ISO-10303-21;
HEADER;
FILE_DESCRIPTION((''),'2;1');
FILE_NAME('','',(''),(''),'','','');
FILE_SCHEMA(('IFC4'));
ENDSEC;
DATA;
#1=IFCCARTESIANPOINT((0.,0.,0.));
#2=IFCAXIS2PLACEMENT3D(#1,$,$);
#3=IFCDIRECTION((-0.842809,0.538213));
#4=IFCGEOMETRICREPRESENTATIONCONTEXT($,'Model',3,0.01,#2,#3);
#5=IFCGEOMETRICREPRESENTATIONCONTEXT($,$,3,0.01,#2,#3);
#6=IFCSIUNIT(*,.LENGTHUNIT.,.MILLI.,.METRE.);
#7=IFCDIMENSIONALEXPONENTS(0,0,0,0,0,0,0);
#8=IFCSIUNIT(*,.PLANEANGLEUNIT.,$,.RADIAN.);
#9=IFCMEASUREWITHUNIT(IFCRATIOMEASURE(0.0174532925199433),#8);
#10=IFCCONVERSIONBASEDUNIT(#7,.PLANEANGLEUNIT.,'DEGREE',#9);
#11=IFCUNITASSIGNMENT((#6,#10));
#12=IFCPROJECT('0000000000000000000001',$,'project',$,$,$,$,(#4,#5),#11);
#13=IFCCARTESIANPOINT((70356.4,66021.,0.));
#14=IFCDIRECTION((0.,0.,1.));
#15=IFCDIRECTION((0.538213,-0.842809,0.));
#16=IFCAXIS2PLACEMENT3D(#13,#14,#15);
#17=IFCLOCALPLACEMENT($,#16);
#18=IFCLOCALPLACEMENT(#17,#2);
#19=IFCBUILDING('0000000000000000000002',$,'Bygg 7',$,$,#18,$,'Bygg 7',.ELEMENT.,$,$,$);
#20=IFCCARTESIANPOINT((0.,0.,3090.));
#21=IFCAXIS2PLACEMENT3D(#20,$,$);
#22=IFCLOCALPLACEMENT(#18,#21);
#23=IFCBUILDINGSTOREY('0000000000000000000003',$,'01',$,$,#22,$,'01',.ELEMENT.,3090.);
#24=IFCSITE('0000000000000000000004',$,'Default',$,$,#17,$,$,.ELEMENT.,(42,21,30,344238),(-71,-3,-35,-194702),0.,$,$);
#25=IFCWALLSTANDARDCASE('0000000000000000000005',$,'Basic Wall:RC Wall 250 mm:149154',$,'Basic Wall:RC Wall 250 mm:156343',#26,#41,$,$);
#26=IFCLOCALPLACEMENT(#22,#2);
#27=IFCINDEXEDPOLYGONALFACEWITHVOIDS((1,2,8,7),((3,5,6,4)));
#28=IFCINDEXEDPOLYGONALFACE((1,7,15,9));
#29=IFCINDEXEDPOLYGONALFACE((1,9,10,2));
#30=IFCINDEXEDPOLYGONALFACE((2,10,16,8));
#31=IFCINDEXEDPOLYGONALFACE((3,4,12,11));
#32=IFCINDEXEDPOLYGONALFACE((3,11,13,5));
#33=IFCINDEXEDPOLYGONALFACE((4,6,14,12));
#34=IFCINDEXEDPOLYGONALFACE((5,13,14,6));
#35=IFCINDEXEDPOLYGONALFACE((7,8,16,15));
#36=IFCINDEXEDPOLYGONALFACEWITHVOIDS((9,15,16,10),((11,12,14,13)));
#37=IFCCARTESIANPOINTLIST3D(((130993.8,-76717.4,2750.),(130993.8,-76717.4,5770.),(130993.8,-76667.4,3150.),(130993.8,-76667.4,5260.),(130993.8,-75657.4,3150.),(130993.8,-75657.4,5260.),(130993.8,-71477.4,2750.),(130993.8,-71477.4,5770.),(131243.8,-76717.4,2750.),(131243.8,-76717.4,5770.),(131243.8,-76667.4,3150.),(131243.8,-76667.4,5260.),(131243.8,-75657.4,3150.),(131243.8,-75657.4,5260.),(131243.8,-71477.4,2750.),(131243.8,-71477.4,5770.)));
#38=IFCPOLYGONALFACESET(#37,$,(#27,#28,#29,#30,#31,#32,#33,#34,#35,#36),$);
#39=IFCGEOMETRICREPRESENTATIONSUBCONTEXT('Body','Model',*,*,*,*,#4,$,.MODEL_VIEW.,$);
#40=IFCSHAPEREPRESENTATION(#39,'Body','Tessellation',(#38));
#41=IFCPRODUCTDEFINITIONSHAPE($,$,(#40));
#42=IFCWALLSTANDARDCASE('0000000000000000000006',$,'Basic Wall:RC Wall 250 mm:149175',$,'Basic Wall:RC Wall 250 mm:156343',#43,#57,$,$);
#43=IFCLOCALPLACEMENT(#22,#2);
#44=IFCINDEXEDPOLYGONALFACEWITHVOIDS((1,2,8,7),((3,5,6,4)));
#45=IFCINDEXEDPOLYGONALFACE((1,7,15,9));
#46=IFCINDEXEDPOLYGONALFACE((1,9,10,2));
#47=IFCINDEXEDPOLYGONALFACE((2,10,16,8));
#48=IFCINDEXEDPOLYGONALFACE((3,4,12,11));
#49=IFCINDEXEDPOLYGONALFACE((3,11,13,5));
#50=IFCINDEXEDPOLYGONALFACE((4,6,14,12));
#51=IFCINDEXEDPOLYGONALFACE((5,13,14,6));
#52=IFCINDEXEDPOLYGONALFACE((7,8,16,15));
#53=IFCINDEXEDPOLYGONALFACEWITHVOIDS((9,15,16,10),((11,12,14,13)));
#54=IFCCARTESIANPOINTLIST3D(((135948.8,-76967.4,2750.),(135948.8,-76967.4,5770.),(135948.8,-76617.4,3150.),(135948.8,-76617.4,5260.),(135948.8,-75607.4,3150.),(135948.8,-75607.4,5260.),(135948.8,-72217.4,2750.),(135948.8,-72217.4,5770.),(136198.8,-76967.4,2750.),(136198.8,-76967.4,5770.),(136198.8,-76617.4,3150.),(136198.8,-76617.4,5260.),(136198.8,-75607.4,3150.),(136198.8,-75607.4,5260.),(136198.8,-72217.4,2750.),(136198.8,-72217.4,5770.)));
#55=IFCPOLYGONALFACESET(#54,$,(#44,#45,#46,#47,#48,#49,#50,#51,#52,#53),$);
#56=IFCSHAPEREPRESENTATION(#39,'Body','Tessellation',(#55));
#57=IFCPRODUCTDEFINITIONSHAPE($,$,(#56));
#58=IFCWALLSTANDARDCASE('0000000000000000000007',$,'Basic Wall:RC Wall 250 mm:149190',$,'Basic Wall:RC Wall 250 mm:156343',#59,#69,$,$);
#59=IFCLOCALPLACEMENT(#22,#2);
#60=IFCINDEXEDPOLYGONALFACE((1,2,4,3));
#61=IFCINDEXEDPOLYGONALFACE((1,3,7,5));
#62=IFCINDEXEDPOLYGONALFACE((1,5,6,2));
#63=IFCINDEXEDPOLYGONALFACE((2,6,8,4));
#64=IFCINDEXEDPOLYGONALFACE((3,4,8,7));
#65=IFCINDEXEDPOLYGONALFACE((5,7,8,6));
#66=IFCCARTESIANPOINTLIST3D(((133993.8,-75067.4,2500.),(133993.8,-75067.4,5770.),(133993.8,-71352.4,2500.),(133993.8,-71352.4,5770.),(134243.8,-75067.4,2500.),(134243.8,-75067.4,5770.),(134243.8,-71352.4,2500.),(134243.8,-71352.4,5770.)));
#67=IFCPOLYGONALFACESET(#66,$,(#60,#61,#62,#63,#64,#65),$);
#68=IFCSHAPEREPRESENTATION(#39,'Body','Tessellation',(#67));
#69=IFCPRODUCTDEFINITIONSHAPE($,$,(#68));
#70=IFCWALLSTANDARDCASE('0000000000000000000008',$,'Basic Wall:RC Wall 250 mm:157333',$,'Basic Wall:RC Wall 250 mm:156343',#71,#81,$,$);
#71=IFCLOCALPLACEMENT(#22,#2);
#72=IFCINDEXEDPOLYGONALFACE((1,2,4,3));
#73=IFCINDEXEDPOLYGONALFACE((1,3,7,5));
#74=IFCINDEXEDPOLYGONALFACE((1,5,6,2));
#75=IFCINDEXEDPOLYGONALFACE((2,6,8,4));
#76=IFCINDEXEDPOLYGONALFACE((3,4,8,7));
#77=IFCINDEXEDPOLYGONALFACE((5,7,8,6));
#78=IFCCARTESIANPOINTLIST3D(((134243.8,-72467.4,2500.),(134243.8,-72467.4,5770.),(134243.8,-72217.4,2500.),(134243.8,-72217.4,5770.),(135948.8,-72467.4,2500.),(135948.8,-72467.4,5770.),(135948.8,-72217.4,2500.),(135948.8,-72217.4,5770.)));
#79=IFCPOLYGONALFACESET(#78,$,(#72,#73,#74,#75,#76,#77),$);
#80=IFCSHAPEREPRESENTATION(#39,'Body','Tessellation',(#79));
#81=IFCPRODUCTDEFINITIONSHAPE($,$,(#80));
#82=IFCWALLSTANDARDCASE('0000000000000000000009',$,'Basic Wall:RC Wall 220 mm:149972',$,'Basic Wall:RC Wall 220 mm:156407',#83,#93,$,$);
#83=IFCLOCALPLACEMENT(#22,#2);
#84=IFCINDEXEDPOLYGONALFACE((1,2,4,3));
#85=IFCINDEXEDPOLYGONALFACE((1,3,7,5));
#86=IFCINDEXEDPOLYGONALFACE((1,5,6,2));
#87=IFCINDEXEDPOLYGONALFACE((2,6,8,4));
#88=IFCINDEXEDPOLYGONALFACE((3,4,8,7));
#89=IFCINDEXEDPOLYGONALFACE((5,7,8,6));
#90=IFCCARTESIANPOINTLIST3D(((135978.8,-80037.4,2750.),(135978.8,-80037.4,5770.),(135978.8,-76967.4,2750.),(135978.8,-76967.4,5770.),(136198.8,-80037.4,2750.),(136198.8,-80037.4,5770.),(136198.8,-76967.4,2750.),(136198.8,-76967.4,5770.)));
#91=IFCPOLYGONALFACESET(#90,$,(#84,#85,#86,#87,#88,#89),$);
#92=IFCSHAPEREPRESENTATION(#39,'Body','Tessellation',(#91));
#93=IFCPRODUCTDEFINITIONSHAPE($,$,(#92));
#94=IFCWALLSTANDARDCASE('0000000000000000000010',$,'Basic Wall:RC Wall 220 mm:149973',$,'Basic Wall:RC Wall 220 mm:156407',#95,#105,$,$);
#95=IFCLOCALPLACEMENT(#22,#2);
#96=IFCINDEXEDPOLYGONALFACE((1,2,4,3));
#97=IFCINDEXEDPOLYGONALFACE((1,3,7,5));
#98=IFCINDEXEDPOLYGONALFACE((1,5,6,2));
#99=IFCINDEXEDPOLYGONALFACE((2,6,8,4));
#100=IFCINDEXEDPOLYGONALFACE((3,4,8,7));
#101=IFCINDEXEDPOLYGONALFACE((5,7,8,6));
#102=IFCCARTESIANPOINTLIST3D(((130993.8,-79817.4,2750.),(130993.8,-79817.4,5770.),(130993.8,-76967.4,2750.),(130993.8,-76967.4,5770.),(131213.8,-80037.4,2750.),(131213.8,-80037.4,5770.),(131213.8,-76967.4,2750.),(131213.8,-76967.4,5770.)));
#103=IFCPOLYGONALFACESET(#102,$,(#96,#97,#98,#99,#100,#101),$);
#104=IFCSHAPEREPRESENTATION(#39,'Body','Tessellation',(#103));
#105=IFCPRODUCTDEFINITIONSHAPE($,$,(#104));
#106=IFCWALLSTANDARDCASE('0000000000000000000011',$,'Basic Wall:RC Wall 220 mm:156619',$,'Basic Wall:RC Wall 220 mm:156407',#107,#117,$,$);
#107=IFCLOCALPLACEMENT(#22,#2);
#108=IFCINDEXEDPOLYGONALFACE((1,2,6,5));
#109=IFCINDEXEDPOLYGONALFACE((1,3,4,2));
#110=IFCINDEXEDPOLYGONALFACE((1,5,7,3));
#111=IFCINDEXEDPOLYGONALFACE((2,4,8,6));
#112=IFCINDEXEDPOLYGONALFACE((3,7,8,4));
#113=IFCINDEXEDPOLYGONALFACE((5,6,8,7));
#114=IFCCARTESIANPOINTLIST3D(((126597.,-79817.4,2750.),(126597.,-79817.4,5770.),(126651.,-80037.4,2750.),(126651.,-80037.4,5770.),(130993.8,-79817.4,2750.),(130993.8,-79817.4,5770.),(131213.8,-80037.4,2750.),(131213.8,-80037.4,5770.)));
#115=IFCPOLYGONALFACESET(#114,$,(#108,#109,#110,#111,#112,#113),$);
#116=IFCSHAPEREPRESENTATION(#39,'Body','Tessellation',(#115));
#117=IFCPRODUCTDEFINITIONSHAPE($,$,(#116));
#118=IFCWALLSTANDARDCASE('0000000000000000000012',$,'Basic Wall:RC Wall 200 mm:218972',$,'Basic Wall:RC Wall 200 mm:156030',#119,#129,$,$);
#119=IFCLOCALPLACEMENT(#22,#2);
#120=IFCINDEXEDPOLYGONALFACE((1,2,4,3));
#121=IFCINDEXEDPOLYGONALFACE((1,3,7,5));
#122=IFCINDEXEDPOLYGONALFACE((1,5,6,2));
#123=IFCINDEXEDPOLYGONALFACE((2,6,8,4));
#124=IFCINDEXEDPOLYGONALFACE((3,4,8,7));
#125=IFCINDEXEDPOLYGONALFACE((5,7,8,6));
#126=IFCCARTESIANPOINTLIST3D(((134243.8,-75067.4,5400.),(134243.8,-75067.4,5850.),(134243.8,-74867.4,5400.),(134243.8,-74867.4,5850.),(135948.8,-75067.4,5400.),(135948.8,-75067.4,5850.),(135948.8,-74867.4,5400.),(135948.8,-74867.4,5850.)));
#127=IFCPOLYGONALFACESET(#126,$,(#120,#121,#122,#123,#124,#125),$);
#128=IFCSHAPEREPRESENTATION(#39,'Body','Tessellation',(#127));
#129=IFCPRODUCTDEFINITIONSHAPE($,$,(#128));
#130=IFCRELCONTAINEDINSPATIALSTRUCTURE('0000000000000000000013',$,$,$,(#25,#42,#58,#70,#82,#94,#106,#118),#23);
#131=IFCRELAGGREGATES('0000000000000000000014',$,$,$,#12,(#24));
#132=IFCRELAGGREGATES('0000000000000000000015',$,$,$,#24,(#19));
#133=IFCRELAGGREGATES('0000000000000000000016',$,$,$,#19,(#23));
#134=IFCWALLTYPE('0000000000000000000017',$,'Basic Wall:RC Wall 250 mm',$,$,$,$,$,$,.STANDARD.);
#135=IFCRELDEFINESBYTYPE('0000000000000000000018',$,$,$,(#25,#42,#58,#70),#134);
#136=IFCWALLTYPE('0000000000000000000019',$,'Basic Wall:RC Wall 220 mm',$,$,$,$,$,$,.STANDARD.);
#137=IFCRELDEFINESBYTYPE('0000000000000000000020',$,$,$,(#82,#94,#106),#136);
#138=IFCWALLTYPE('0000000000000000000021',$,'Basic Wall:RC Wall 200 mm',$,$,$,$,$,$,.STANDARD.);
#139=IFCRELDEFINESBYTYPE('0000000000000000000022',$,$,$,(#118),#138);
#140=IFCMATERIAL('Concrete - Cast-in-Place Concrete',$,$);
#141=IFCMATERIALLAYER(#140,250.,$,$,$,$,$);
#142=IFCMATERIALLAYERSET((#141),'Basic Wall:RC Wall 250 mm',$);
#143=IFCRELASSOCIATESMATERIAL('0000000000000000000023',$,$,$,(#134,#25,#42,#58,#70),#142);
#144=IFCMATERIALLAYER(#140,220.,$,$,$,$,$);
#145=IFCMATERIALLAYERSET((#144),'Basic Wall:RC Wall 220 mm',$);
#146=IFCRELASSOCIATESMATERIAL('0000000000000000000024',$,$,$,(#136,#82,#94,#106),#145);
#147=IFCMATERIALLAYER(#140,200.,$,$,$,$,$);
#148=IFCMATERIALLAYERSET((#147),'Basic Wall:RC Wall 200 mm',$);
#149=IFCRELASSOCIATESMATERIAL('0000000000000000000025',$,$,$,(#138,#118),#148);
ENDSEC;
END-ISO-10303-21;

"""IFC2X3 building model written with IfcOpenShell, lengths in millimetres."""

from ifc_helpers import new_model, entity, si_unit, converted_unit, direction, frame, frame_2d, origin, origin_2d_with_axis, place, context, subcontext, project, spatial, polyline, rectangle, outline, extrude, clip, bounded_halfspace, material, layer, layer_set, layer_usage, type_object, element, save


model = new_model("IFC2X3")

# Units and contexts
model_context = context("Model", 3, precision=0.01, world=origin(), true_north=direction((-0.842809, 0.538213)))
context_of_model = context(None, 3, precision=0.01, world=origin(), true_north=direction((-0.842809, 0.538213)))
body_context = subcontext(model_context, "Body", "Model", "MODEL_VIEW")
ifc_project = project(units=[si_unit("LENGTHUNIT", "METRE", prefix="MILLI"), converted_unit("PLANEANGLEUNIT", "DEGREE", entity("IfcRatioMeasure", 0.0174532925199433), si_unit("PLANEANGLEUNIT", "RADIAN"), dimensions=[0, 0, 0, 0, 0, 0, 0])], contexts=[model_context, context_of_model])

# Site, building, storey
site_placement = place(None, frame((70356.4, 66021.0, 0.0), z_axis=(0.0, 0.0, 1.0), x_axis=(0.538213, -0.842809, 0.0)))
site = spatial("IfcSite", under=ifc_project, at=site_placement, Name="Default", CompositionType="ELEMENT", RefLatitude=(42, 21, 30, 344238), RefLongitude=(-71, -3, -35, -194702), RefElevation=0.0)
building_placement = place(site_placement, origin())
building = spatial("IfcBuilding", under=site, at=building_placement, Name="Bygg 7", LongName="Bygg 7", CompositionType="ELEMENT")
storey_placement = place(building_placement, frame((0.0, 0.0, 3090.0)))
storey = spatial("IfcBuildingStorey", under=building, at=storey_placement, Name="01", LongName="01", CompositionType="ELEMENT", Elevation=3090.0)

# Shared definitions
ifc_material = material(Name="Concrete - Cast-in-Place Concrete")

# Walls, openings
ifc_layer_1 = layer(ifc_material, 250.0)
ifc_layer_set_1 = layer_set([ifc_layer_1], Name="Basic Wall:RC Wall 250 mm")
ifc_layer_usage_1 = layer_usage(ifc_layer_set_1, "AXIS2", "NEGATIVE", 125.0)
wall_type_1 = type_object("IfcWallType", Name="Basic Wall:RC Wall 250 mm", PredefinedType="STANDARD", material=ifc_layer_set_1)
wall_1_placement = place(storey_placement, frame((131118.8, -76717.4, 2750.0), z_axis=(0.0, 0.0, 1.0), x_axis=(0.0, 1.0, 0.0)))
wall_1 = element("IfcWallStandardCase", 1, at=wall_1_placement, inside=storey, type_object=wall_type_1, material=ifc_layer_usage_1, Name="Basic Wall:RC Wall 250 mm:149154", ObjectType="Basic Wall:RC Wall 250 mm:156343", context=body_context, shape_type="Clipping", body=[
    clip(extrude(rectangle(XDim=5240.0, YDim=250.0, at=frame_2d((2620.0, 0.0), x_axis=(-1.0, 0.0))), origin(), (0.0, 0.0, 1.0), 3020.0), bounded_halfspace(frame((0.0, -125.0, 3020.0), z_axis=(0.0, 0.0, -1.0), x_axis=(0.0, -1.0, 0.0)), True, frame((0.0, -125.0, 3020.0)), polyline([(0.0, 0.0), (5240.0, 0.0), (5240.0, 250.0), (0.0, 250.0), (0.0, 0.0)]))),
])
opening_1_placement = place(wall_1_placement, origin())
element("IfcOpeningElement", 2, at=opening_1_placement, cuts=wall_1, ObjectType="Opening", context=body_context, shape_type="SweptSolid", body=[
    extrude(rectangle(XDim=2110.0, YDim=1010.0, at=origin_2d_with_axis()), frame((555.0, -125.0, 1455.0), z_axis=(0.0, 1.0, 0.0), x_axis=(0.0, 0.0, -1.0)), (0.0, 0.0, 1.0), 250.0),
])
ifc_layer_usage_2 = layer_usage(ifc_layer_set_1, "AXIS2", "NEGATIVE", 125.0)
wall_2_placement = place(storey_placement, frame((136073.8, -76967.4, 2750.0), z_axis=(0.0, 0.0, 1.0), x_axis=(0.0, 1.0, 0.0)))
wall_2 = element("IfcWallStandardCase", 3, at=wall_2_placement, inside=storey, type_object=wall_type_1, material=ifc_layer_usage_2, Name="Basic Wall:RC Wall 250 mm:149175", ObjectType="Basic Wall:RC Wall 250 mm:156343", context=body_context, shape_type="Clipping", body=[
    clip(extrude(rectangle(XDim=4750.0, YDim=250.0, at=frame_2d((2375.0, 0.0), x_axis=(-1.0, 0.0))), origin(), (0.0, 0.0, 1.0), 3020.0), bounded_halfspace(frame((4750.0, 125.0, 3020.0), z_axis=(0.0, 0.0, -1.0), x_axis=(0.0, -1.0, 0.0)), True, frame((4750.0, 125.0, 3020.0)), polyline([(0.0, 0.0), (-250.0, 0.0), (-4500.0, 0.0), (-4750.0, 0.0), (-4750.0, -30.0), (-4750.0, -250.0), (0.0, -250.0), (0.0, -139.0), (0.0, 0.0)]))),
])
opening_2_placement = place(wall_2_placement, origin())
element("IfcOpeningElement", 4, at=opening_2_placement, cuts=wall_2, ObjectType="Opening", context=body_context, shape_type="SweptSolid", body=[
    extrude(rectangle(XDim=2110.0, YDim=1010.0, at=origin_2d_with_axis()), frame((855.0, -125.0, 1455.0), z_axis=(0.0, 1.0, 0.0), x_axis=(0.0, 0.0, -1.0)), (0.0, 0.0, 1.0), 250.0),
])

# Walls
ifc_layer_usage_3 = layer_usage(ifc_layer_set_1, "AXIS2", "NEGATIVE", 125.0)
wall_3_placement = place(storey_placement, frame((134118.8, -75067.4, 2500.0), z_axis=(0.0, 0.0, 1.0), x_axis=(0.0, 1.0, 0.0)))
element("IfcWallStandardCase", 5, at=wall_3_placement, inside=storey, type_object=wall_type_1, material=ifc_layer_usage_3, Name="Basic Wall:RC Wall 250 mm:149190", ObjectType="Basic Wall:RC Wall 250 mm:156343", context=body_context, shape_type="Clipping", body=[
    clip(extrude(rectangle(XDim=3715.0, YDim=250.0, at=frame_2d((1857.5, 0.0), x_axis=(-1.0, 0.0))), origin(), (0.0, 0.0, 1.0), 3270.0), bounded_halfspace(frame((3311.0, -125.0, 3270.0), z_axis=(0.0, 0.0, -1.0), x_axis=(0.0, -1.0, 0.0)), True, frame((3311.0, -125.0, 3270.0)), polyline([(0.0, 0.0), (404.0, 0.0), (404.0, 250.0), (279.0, 250.0), (0.0, 250.0), (0.0, 0.0)]))),
])
ifc_layer_usage_4 = layer_usage(ifc_layer_set_1, "AXIS2", "NEGATIVE", 125.0)
wall_4_placement = place(storey_placement, frame((134243.8, -72342.4, 2500.0)))
element("IfcWallStandardCase", 6, at=wall_4_placement, inside=storey, type_object=wall_type_1, material=ifc_layer_usage_4, Name="Basic Wall:RC Wall 250 mm:157333", ObjectType="Basic Wall:RC Wall 250 mm:156343", context=body_context, shape_type="SweptSolid", body=[
    extrude(rectangle(XDim=1705.0, YDim=250.0, at=frame_2d((852.5, 0.0), x_axis=(-1.0, 0.0))), origin(), (0.0, 0.0, 1.0), 3270.0),
])

# Walls
ifc_layer_2 = layer(ifc_material, 220.0)
ifc_layer_set_2 = layer_set([ifc_layer_2], Name="Basic Wall:RC Wall 220 mm")
ifc_layer_usage_5 = layer_usage(ifc_layer_set_2, "AXIS2", "NEGATIVE", 110.0)
wall_type_2 = type_object("IfcWallType", Name="Basic Wall:RC Wall 220 mm", PredefinedType="STANDARD", material=ifc_layer_set_2)
wall_5_placement = place(storey_placement, frame((136088.8, -80037.4, 2750.0), z_axis=(0.0, 0.0, 1.0), x_axis=(0.0, 1.0, 0.0)))
element("IfcWallStandardCase", 7, at=wall_5_placement, inside=storey, type_object=wall_type_2, material=ifc_layer_usage_5, Name="Basic Wall:RC Wall 220 mm:149972", ObjectType="Basic Wall:RC Wall 220 mm:156407", context=body_context, shape_type="Clipping", body=[
    clip(extrude(rectangle(XDim=3070.0, YDim=220.0, at=frame_2d((1535.0, 0.0), x_axis=(-1.0, 0.0))), origin(), (0.0, 0.0, 1.0), 3020.0), bounded_halfspace(frame((0.0, -110.0, 3020.0), z_axis=(0.0, 0.0, -1.0), x_axis=(0.0, -1.0, 0.0)), True, frame((0.0, -110.0, 3020.0)), polyline([(0.0, 0.0), (220.0, 0.0), (3070.0, 0.0), (3070.0, 220.0), (674.0, 220.0), (0.0, 220.0), (0.0, 0.0)]))),
])
ifc_layer_usage_6 = layer_usage(ifc_layer_set_2, "AXIS2", "NEGATIVE", 110.0)
wall_6_placement = place(storey_placement, frame((131103.8, -80037.4, 2750.0), z_axis=(0.0, 0.0, 1.0), x_axis=(0.0, 1.0, 0.0)))
element("IfcWallStandardCase", 8, at=wall_6_placement, inside=storey, type_object=wall_type_2, material=ifc_layer_usage_6, Name="Basic Wall:RC Wall 220 mm:149973", ObjectType="Basic Wall:RC Wall 220 mm:156407", context=body_context, shape_type="Clipping", body=[
    clip(extrude(outline(polyline([(3070.0, -110.0), (3070.0, 110.0), (220.0, 110.0), (0.0, -110.0), (3070.0, -110.0)])), origin(), (0.0, 0.0, 1.0), 3020.0), bounded_halfspace(frame((0.0, -110.0, 3020.0), z_axis=(0.0, 0.0, -1.0), x_axis=(0.0, -1.0, 0.0)), True, frame((0.0, -110.0, 3020.0)), polyline([(0.0, 0.0), (3070.0, 0.0), (3070.0, 220.0), (220.0, 220.0), (0.0, 0.0)]))),
])

# Wall, opening
ifc_layer_usage_7 = layer_usage(ifc_layer_set_2, "AXIS2", "NEGATIVE", 110.0)
wall_7_placement = place(storey_placement, frame((126597.0, -79927.4, 2750.0)))
wall_7 = element("IfcWallStandardCase", 9, at=wall_7_placement, inside=storey, type_object=wall_type_2, material=ifc_layer_usage_7, Name="Basic Wall:RC Wall 220 mm:156619", ObjectType="Basic Wall:RC Wall 220 mm:156407", context=body_context, shape_type="Clipping", body=[
    clip(extrude(outline(polyline([(4396.8, 110.0), (0.0, 110.0), (54.0, -110.0), (4616.8, -110.0), (4396.8, 110.0)])), origin(), (0.0, 0.0, 1.0), 3020.0), bounded_halfspace(frame((54.0, -110.0, 3020.0), z_axis=(0.0, 0.0, -1.0), x_axis=(1.0, 0.0, 0.0)), True, frame((54.0, -110.0, 3020.0)), polyline([(0.0, 0.0), (4562.8, 0.0), (4342.8, 220.0), (-54.0, 220.0), (0.0, 0.0)]))),
])
opening_3_placement = place(wall_7_placement, origin())
element("IfcOpeningElement", 10, at=opening_3_placement, cuts=wall_7, ObjectType="Opening", context=body_context, shape_type="SweptSolid", body=[
    extrude(rectangle(XDim=250.0, YDim=380.5, at=origin_2d_with_axis()), frame((-104.0, 9.4, -4045.9), z_axis=(0.0, 0.0, 1.0), x_axis=(-0.971172, -0.238381, 0.0)), (0.0, 0.0, 1.0), 18915.9),
])

# Wall
ifc_layer_3 = layer(ifc_material, 200.0)
ifc_layer_set_3 = layer_set([ifc_layer_3], Name="Basic Wall:RC Wall 200 mm")
ifc_layer_usage_8 = layer_usage(ifc_layer_set_3, "AXIS2", "NEGATIVE", 100.0)
wall_type_3 = type_object("IfcWallType", Name="Basic Wall:RC Wall 200 mm", PredefinedType="STANDARD", material=ifc_layer_set_3)
wall_8_placement = place(storey_placement, frame((134243.8, -74967.4, 5400.0)))
element("IfcWallStandardCase", 11, at=wall_8_placement, inside=storey, type_object=wall_type_3, material=ifc_layer_usage_8, Name="Basic Wall:RC Wall 200 mm:218972", ObjectType="Basic Wall:RC Wall 200 mm:156030", context=body_context, shape_type="Clipping", body=[
    clip(extrude(rectangle(XDim=1705.0, YDim=200.0, at=frame_2d((852.5, 0.0), x_axis=(-1.0, 0.0))), origin(), (0.0, 0.0, 1.0), 450.0), bounded_halfspace(frame((0.0, -100.0, 450.0), z_axis=(0.0, 0.0, -1.0), x_axis=(1.0, 0.0, 0.0)), True, frame((0.0, -100.0, 450.0)), polyline([(0.0, 0.0), (1705.0, 0.0), (1705.0, 200.0), (0.0, 200.0), (0.0, 0.0)]))),
])

save(model, "model.ifc")
